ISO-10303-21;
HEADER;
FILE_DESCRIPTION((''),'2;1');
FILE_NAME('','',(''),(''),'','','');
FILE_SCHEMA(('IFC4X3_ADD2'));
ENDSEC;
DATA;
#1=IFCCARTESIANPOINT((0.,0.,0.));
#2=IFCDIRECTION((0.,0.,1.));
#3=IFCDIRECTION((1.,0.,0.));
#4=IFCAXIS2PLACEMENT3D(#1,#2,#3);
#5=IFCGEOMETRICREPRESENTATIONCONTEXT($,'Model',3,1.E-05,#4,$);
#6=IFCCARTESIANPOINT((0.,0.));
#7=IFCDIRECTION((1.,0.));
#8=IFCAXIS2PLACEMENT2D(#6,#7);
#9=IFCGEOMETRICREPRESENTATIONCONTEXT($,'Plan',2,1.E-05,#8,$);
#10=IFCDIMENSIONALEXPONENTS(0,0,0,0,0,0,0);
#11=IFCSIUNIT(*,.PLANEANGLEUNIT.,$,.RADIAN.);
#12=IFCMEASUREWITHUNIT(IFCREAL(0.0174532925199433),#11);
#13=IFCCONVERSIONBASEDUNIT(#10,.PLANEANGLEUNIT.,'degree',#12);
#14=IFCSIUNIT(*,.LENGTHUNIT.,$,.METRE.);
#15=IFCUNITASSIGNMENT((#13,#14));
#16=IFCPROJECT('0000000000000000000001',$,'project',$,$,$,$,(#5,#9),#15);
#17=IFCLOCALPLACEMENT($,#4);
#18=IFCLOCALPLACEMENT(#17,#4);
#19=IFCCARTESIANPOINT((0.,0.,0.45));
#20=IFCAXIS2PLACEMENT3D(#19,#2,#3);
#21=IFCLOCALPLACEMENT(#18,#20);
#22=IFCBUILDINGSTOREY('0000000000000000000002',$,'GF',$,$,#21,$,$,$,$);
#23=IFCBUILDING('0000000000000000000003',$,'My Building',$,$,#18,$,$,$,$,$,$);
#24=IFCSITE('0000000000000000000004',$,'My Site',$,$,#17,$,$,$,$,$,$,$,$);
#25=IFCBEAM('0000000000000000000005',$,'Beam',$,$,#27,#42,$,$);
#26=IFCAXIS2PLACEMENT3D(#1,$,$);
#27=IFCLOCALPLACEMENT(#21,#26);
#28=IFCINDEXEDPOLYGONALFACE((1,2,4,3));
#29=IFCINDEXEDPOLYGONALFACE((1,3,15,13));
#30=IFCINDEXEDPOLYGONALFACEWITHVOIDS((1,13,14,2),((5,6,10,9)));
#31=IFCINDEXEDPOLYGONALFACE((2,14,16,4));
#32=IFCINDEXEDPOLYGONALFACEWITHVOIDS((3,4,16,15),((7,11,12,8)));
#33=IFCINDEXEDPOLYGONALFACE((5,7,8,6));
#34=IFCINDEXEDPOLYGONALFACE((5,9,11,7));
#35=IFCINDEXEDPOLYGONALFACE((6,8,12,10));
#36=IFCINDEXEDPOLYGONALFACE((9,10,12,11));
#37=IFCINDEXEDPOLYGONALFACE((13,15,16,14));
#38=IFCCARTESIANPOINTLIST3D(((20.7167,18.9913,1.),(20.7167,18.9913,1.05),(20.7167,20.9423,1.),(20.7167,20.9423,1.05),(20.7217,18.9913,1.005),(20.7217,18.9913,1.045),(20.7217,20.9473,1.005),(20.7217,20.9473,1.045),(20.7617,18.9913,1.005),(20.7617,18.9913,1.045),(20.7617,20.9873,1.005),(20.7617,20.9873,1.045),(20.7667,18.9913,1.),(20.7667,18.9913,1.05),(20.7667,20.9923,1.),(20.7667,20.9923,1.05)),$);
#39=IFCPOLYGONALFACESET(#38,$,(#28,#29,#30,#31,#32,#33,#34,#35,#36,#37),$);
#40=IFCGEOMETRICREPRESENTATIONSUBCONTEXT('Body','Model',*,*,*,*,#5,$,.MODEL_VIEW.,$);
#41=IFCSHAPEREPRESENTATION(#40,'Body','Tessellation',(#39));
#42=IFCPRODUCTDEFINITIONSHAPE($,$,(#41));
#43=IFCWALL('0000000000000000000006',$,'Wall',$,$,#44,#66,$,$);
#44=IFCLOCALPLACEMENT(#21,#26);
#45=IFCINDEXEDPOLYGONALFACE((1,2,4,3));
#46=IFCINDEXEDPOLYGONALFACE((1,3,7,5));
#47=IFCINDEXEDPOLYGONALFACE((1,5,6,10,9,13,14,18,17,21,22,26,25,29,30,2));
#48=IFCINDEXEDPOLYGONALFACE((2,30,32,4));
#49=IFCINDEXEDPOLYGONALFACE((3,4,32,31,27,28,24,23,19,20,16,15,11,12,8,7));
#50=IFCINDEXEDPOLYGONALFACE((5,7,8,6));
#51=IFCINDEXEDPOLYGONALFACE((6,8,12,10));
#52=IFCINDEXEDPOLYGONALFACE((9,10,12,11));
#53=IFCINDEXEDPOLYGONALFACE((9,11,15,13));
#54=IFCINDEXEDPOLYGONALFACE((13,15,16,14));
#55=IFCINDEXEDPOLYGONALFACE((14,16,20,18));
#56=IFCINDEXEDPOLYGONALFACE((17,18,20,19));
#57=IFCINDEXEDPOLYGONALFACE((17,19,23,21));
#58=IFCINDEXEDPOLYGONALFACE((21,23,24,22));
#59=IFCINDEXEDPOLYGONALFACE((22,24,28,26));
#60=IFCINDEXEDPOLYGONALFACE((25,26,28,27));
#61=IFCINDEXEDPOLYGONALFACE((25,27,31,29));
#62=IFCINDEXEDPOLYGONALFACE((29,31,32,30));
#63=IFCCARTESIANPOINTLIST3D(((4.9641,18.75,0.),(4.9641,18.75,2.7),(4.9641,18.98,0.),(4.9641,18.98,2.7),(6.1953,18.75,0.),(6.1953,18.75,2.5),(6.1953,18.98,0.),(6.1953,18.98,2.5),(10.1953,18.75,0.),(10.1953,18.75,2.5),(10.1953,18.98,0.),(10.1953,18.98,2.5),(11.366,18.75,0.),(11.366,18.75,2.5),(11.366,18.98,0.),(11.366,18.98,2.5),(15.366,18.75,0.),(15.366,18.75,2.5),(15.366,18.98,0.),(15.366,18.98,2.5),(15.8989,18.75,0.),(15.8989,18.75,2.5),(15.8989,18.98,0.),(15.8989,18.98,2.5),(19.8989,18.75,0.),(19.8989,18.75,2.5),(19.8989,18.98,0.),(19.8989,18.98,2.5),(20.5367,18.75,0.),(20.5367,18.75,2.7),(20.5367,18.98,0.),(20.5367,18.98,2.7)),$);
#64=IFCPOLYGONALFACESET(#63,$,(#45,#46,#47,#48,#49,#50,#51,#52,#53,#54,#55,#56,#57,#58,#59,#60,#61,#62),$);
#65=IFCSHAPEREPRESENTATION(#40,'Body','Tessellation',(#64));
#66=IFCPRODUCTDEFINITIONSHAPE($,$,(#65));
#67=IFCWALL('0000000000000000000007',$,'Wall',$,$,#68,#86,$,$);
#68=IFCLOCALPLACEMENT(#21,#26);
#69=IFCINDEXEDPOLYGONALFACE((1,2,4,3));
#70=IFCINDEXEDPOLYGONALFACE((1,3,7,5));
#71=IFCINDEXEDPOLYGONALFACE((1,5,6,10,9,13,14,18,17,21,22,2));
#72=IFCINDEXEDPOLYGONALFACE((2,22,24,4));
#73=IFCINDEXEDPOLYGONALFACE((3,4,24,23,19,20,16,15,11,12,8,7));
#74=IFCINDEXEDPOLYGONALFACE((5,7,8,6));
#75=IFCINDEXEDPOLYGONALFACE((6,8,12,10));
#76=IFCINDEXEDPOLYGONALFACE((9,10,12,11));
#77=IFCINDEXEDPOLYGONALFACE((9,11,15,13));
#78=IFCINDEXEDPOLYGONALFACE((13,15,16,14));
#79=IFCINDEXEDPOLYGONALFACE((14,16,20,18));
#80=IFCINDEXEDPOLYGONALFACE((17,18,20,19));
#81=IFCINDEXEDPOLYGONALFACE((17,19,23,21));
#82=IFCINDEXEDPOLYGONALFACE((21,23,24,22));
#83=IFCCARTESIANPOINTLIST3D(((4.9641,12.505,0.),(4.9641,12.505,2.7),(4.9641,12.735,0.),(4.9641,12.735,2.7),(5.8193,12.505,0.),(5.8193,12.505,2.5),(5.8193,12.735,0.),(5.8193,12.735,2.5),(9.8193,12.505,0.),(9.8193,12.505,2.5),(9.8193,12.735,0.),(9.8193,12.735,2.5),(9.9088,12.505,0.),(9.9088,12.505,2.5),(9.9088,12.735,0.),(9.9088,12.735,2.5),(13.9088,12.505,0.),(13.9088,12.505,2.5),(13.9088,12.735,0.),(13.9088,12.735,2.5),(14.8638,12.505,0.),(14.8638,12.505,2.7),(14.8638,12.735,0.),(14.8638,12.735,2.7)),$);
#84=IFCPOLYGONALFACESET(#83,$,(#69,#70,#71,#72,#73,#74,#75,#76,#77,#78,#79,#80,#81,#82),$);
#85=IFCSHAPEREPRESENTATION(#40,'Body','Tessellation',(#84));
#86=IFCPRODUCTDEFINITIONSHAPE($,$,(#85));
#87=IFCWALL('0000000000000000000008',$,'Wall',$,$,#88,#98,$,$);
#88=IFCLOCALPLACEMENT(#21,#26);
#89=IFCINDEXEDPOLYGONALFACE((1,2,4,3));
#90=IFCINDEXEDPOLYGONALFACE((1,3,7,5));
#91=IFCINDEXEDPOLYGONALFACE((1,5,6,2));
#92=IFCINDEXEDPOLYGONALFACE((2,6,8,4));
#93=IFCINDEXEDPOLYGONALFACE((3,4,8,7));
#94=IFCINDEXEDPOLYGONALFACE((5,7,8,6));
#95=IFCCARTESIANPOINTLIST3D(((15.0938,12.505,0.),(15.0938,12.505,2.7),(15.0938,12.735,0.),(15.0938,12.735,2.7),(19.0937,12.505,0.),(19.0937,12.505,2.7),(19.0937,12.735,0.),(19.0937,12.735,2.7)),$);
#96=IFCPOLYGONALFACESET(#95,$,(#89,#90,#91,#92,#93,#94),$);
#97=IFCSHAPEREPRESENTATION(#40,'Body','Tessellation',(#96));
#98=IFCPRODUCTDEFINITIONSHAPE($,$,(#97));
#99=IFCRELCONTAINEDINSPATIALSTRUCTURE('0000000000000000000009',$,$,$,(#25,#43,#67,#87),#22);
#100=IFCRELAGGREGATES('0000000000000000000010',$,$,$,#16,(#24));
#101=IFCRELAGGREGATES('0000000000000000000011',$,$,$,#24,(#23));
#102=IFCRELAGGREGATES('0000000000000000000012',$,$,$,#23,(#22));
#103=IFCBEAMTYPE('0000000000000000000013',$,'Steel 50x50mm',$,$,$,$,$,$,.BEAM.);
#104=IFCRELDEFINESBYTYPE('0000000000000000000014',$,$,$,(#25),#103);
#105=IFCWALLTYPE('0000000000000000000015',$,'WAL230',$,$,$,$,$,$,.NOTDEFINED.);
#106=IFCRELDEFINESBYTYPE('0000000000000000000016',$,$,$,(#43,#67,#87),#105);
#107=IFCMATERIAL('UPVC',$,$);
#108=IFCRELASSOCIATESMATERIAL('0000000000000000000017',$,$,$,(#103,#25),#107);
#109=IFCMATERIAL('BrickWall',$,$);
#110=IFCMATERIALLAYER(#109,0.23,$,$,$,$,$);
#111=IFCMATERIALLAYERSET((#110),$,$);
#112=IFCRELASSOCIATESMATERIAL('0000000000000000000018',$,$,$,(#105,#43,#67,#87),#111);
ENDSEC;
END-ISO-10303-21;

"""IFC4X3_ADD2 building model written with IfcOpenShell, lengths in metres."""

from ifc_helpers import new_model, entity, si_unit, converted_unit, frame, origin_with_axes, origin_2d_with_axis, place, context, subcontext, project, spatial, line, indexed_curve, hollow_rectangle, outline, extrude, clip, halfspace, source, transform, mapped, material, layer, layer_set, layer_usage, material_profile, profile_set, profile_usage, type_object, element, save


model = new_model("IFC4X3_ADD2")

# Units and contexts
model_context = context("Model", 3, precision=1e-05, world=origin_with_axes())
plan_context = context("Plan", 2, precision=1e-05, world=origin_2d_with_axis())
body_context_1 = subcontext(model_context, "Body", "Model", "MODEL_VIEW")
ifc_project = project(units=[converted_unit("PLANEANGLEUNIT", "degree", entity("IfcReal", 0.0174532925199433), si_unit("PLANEANGLEUNIT", "RADIAN"), dimensions=[0, 0, 0, 0, 0, 0, 0]), si_unit("LENGTHUNIT", "METRE")], contexts=[model_context, plan_context])

# Site, building, storey
site_placement = place(None, origin_with_axes())
site = spatial("IfcSite", under=ifc_project, at=site_placement, Name="My Site")
building_placement = place(site_placement, origin_with_axes())
building = spatial("IfcBuilding", under=site, at=building_placement, Name="My Building")
storey_placement = place(building_placement, frame((0.0, 0.0, 0.45), z_axis=(0.0, 0.0, 1.0), x_axis=(1.0, 0.0, 0.0)))
storey = spatial("IfcBuildingStorey", under=building, at=storey_placement, Name="GF")

# Beam
ifc_material_1 = material(Name="UPVC")
ifc_material_profile_1 = material_profile(ifc_material_1, hollow_rectangle(XDim=0.05, YDim=0.05, WallThickness=0.005))
ifc_material_profile_2 = material_profile(ifc_material_1, hollow_rectangle(XDim=0.05, YDim=0.05, WallThickness=0.005))
ifc_profile_set = profile_set([ifc_material_profile_1, ifc_material_profile_2])
ifc_profile_usage = profile_usage(ifc_profile_set, cardinal=5)
beam_type = type_object("IfcBeamType", Name="Steel 50x50mm", PredefinedType="BEAM", material=ifc_profile_set)
beam_placement = place(storey_placement, frame((20.7417, 18.9913, 1.025), z_axis=(0.0, 1.0, 0.0), x_axis=(-1.0, 0.0, 0.0)))
element("IfcBeam", 1, at=beam_placement, inside=storey, type_object=beam_type, material=ifc_profile_usage, Name="Beam", context=body_context_1, shape_type="Clipping", body=[
    clip(extrude(hollow_rectangle(XDim=0.05, YDim=0.05, WallThickness=0.005), origin_with_axes(), (0.0, 0.0, 1.0), 2.0009), halfspace(frame((-0.025, -1.475, 2.0009), z_axis=(0.707107, 0.0, 0.707107), x_axis=(0.0, -1.0, 0.0)), False)),
])

# Walls, openings
ifc_material_2 = material(Name="BrickWall")
ifc_layer_1 = layer(ifc_material_2, 0.23)
ifc_layer_set_1 = layer_set([ifc_layer_1])
ifc_layer_usage_1 = layer_usage(ifc_layer_set_1, "AXIS2", "POSITIVE", 0.0)
wall_type_1 = type_object("IfcWallType", Name="WAL230", PredefinedType="NOTDEFINED", material=ifc_layer_set_1)
wall_1_placement = place(storey_placement, frame((20.5367, 18.98, 0.0), z_axis=(0.0, 0.0, 1.0), x_axis=(-1.0, 0.0, 0.0)))
wall_1 = element("IfcWall", 2, at=wall_1_placement, inside=storey, type_object=wall_type_1, material=ifc_layer_usage_1, Name="Wall", context=body_context_1, shape_type="SweptSolid", body=[
    extrude(outline(indexed_curve([(0.0, 0.0), (0.0, 0.23), (15.5727, 0.23), (15.5727, 0.0), (0.0, 0.0)], self_intersect=False)), origin_with_axes(), (0.0, 0.0, 1.0), 2.7),
])
shared_shape_1 = source(origin_with_axes(), body_context_1, "Body", "SweptSolid", [
    extrude(outline(indexed_curve([(0.0, 0.0), (4.0, 0.0), (4.0, 2.5), (0.0, 2.5)], segments=[line(1, 2, 3, 4, 1)])), frame((0.0, -0.6, 0.0), z_axis=(0.0, -1.0, 0.0), x_axis=(1.0, 0.0, 0.0)), (0.0, 0.0, -1.0), 1.2),
])
opening_1_placement = place(wall_1_placement, frame((10.3415, 0.0, 0.0), z_axis=(0.0, 0.0, 1.0), x_axis=(1.0, 0.0, 0.0)))
element("IfcOpeningElement", 3, at=opening_1_placement, cuts=wall_1, PredefinedType="OPENING", context=body_context_1, shape_type="MappedRepresentation", body=[
    mapped(shared_shape_1, transform((0.0, 0.0, 0.0), x_axis=(1.0, 0.0, 0.0), y_axis=(0.0, 1.0, 0.0), z_axis=(0.0, 0.0, 1.0), scale=1.0)),
])
opening_2_placement = place(wall_1_placement, frame((5.1707, 0.0, 0.0), z_axis=(0.0, 0.0, 1.0), x_axis=(1.0, 0.0, 0.0)))
element("IfcOpeningElement", 4, at=opening_2_placement, cuts=wall_1, PredefinedType="OPENING", context=body_context_1, shape_type="MappedRepresentation", body=[
    mapped(shared_shape_1, transform((0.0, 0.0, 0.0), x_axis=(1.0, 0.0, 0.0), y_axis=(0.0, 1.0, 0.0), z_axis=(0.0, 0.0, 1.0), scale=1.0)),
])
opening_3_placement = place(wall_1_placement, frame((0.6379, 0.0, 0.0), z_axis=(0.0, 0.0, 1.0), x_axis=(1.0, 0.0, 0.0)))
element("IfcOpeningElement", 5, at=opening_3_placement, cuts=wall_1, PredefinedType="OPENING", context=body_context_1, shape_type="MappedRepresentation", body=[
    mapped(shared_shape_1, transform((0.0, 0.0, 0.0), x_axis=(1.0, 0.0, 0.0), y_axis=(0.0, 1.0, 0.0), z_axis=(0.0, 0.0, 1.0), scale=1.0)),
])
ifc_layer_usage_2 = layer_usage(ifc_layer_set_1, "AXIS2", "POSITIVE", 0.0)
wall_2_placement = place(storey_placement, frame((14.8638, 12.735, 0.0), z_axis=(0.0, 0.0, 1.0), x_axis=(-1.0, 0.0, 0.0)))
wall_2 = element("IfcWall", 6, at=wall_2_placement, inside=storey, type_object=wall_type_1, material=ifc_layer_usage_2, Name="Wall", context=body_context_1, shape_type="SweptSolid", body=[
    extrude(outline(indexed_curve([(0.0, 0.0), (0.0, 0.23), (9.8997, 0.23), (9.8997, 0.0), (0.0, 0.0)], self_intersect=False)), origin_with_axes(), (0.0, 0.0, 1.0), 2.7),
])
opening_4_placement = place(wall_2_placement, frame((5.0445, 0.0, 0.0), z_axis=(0.0, 0.0, 1.0), x_axis=(1.0, 0.0, 0.0)))
element("IfcOpeningElement", 7, at=opening_4_placement, cuts=wall_2, PredefinedType="OPENING", context=body_context_1, shape_type="MappedRepresentation", body=[
    mapped(shared_shape_1, transform((0.0, 0.0, 0.0), x_axis=(1.0, 0.0, 0.0), y_axis=(0.0, 1.0, 0.0), z_axis=(0.0, 0.0, 1.0), scale=1.0)),
])
opening_5_placement = place(wall_2_placement, frame((0.955, 0.0, 0.0), z_axis=(0.0, 0.0, 1.0), x_axis=(1.0, 0.0, 0.0)))
element("IfcOpeningElement", 8, at=opening_5_placement, cuts=wall_2, PredefinedType="OPENING", context=body_context_1, shape_type="MappedRepresentation", body=[
    mapped(shared_shape_1, transform((0.0, 0.0, 0.0), x_axis=(1.0, 0.0, 0.0), y_axis=(0.0, 1.0, 0.0), z_axis=(0.0, 0.0, 1.0), scale=1.0)),
])

# Wall
ifc_layer_usage_3 = layer_usage(ifc_layer_set_1, "AXIS2", "POSITIVE", 0.0)
wall_3_placement = place(storey_placement, frame((19.0937, 12.735, 0.0), z_axis=(0.0, 0.0, 1.0), x_axis=(-1.0, 0.0, 0.0)))
element("IfcWall", 9, at=wall_3_placement, inside=storey, type_object=wall_type_1, material=ifc_layer_usage_3, Name="Wall", context=body_context_1, shape_type="SweptSolid", body=[
    extrude(outline(indexed_curve([(0.0, 0.0), (0.0, 0.23), (3.9999, 0.23), (3.9999, 0.0), (0.0, 0.0)], self_intersect=False)), origin_with_axes(), (0.0, 0.0, 1.0), 2.7),
])

save(model, "model.ifc")
